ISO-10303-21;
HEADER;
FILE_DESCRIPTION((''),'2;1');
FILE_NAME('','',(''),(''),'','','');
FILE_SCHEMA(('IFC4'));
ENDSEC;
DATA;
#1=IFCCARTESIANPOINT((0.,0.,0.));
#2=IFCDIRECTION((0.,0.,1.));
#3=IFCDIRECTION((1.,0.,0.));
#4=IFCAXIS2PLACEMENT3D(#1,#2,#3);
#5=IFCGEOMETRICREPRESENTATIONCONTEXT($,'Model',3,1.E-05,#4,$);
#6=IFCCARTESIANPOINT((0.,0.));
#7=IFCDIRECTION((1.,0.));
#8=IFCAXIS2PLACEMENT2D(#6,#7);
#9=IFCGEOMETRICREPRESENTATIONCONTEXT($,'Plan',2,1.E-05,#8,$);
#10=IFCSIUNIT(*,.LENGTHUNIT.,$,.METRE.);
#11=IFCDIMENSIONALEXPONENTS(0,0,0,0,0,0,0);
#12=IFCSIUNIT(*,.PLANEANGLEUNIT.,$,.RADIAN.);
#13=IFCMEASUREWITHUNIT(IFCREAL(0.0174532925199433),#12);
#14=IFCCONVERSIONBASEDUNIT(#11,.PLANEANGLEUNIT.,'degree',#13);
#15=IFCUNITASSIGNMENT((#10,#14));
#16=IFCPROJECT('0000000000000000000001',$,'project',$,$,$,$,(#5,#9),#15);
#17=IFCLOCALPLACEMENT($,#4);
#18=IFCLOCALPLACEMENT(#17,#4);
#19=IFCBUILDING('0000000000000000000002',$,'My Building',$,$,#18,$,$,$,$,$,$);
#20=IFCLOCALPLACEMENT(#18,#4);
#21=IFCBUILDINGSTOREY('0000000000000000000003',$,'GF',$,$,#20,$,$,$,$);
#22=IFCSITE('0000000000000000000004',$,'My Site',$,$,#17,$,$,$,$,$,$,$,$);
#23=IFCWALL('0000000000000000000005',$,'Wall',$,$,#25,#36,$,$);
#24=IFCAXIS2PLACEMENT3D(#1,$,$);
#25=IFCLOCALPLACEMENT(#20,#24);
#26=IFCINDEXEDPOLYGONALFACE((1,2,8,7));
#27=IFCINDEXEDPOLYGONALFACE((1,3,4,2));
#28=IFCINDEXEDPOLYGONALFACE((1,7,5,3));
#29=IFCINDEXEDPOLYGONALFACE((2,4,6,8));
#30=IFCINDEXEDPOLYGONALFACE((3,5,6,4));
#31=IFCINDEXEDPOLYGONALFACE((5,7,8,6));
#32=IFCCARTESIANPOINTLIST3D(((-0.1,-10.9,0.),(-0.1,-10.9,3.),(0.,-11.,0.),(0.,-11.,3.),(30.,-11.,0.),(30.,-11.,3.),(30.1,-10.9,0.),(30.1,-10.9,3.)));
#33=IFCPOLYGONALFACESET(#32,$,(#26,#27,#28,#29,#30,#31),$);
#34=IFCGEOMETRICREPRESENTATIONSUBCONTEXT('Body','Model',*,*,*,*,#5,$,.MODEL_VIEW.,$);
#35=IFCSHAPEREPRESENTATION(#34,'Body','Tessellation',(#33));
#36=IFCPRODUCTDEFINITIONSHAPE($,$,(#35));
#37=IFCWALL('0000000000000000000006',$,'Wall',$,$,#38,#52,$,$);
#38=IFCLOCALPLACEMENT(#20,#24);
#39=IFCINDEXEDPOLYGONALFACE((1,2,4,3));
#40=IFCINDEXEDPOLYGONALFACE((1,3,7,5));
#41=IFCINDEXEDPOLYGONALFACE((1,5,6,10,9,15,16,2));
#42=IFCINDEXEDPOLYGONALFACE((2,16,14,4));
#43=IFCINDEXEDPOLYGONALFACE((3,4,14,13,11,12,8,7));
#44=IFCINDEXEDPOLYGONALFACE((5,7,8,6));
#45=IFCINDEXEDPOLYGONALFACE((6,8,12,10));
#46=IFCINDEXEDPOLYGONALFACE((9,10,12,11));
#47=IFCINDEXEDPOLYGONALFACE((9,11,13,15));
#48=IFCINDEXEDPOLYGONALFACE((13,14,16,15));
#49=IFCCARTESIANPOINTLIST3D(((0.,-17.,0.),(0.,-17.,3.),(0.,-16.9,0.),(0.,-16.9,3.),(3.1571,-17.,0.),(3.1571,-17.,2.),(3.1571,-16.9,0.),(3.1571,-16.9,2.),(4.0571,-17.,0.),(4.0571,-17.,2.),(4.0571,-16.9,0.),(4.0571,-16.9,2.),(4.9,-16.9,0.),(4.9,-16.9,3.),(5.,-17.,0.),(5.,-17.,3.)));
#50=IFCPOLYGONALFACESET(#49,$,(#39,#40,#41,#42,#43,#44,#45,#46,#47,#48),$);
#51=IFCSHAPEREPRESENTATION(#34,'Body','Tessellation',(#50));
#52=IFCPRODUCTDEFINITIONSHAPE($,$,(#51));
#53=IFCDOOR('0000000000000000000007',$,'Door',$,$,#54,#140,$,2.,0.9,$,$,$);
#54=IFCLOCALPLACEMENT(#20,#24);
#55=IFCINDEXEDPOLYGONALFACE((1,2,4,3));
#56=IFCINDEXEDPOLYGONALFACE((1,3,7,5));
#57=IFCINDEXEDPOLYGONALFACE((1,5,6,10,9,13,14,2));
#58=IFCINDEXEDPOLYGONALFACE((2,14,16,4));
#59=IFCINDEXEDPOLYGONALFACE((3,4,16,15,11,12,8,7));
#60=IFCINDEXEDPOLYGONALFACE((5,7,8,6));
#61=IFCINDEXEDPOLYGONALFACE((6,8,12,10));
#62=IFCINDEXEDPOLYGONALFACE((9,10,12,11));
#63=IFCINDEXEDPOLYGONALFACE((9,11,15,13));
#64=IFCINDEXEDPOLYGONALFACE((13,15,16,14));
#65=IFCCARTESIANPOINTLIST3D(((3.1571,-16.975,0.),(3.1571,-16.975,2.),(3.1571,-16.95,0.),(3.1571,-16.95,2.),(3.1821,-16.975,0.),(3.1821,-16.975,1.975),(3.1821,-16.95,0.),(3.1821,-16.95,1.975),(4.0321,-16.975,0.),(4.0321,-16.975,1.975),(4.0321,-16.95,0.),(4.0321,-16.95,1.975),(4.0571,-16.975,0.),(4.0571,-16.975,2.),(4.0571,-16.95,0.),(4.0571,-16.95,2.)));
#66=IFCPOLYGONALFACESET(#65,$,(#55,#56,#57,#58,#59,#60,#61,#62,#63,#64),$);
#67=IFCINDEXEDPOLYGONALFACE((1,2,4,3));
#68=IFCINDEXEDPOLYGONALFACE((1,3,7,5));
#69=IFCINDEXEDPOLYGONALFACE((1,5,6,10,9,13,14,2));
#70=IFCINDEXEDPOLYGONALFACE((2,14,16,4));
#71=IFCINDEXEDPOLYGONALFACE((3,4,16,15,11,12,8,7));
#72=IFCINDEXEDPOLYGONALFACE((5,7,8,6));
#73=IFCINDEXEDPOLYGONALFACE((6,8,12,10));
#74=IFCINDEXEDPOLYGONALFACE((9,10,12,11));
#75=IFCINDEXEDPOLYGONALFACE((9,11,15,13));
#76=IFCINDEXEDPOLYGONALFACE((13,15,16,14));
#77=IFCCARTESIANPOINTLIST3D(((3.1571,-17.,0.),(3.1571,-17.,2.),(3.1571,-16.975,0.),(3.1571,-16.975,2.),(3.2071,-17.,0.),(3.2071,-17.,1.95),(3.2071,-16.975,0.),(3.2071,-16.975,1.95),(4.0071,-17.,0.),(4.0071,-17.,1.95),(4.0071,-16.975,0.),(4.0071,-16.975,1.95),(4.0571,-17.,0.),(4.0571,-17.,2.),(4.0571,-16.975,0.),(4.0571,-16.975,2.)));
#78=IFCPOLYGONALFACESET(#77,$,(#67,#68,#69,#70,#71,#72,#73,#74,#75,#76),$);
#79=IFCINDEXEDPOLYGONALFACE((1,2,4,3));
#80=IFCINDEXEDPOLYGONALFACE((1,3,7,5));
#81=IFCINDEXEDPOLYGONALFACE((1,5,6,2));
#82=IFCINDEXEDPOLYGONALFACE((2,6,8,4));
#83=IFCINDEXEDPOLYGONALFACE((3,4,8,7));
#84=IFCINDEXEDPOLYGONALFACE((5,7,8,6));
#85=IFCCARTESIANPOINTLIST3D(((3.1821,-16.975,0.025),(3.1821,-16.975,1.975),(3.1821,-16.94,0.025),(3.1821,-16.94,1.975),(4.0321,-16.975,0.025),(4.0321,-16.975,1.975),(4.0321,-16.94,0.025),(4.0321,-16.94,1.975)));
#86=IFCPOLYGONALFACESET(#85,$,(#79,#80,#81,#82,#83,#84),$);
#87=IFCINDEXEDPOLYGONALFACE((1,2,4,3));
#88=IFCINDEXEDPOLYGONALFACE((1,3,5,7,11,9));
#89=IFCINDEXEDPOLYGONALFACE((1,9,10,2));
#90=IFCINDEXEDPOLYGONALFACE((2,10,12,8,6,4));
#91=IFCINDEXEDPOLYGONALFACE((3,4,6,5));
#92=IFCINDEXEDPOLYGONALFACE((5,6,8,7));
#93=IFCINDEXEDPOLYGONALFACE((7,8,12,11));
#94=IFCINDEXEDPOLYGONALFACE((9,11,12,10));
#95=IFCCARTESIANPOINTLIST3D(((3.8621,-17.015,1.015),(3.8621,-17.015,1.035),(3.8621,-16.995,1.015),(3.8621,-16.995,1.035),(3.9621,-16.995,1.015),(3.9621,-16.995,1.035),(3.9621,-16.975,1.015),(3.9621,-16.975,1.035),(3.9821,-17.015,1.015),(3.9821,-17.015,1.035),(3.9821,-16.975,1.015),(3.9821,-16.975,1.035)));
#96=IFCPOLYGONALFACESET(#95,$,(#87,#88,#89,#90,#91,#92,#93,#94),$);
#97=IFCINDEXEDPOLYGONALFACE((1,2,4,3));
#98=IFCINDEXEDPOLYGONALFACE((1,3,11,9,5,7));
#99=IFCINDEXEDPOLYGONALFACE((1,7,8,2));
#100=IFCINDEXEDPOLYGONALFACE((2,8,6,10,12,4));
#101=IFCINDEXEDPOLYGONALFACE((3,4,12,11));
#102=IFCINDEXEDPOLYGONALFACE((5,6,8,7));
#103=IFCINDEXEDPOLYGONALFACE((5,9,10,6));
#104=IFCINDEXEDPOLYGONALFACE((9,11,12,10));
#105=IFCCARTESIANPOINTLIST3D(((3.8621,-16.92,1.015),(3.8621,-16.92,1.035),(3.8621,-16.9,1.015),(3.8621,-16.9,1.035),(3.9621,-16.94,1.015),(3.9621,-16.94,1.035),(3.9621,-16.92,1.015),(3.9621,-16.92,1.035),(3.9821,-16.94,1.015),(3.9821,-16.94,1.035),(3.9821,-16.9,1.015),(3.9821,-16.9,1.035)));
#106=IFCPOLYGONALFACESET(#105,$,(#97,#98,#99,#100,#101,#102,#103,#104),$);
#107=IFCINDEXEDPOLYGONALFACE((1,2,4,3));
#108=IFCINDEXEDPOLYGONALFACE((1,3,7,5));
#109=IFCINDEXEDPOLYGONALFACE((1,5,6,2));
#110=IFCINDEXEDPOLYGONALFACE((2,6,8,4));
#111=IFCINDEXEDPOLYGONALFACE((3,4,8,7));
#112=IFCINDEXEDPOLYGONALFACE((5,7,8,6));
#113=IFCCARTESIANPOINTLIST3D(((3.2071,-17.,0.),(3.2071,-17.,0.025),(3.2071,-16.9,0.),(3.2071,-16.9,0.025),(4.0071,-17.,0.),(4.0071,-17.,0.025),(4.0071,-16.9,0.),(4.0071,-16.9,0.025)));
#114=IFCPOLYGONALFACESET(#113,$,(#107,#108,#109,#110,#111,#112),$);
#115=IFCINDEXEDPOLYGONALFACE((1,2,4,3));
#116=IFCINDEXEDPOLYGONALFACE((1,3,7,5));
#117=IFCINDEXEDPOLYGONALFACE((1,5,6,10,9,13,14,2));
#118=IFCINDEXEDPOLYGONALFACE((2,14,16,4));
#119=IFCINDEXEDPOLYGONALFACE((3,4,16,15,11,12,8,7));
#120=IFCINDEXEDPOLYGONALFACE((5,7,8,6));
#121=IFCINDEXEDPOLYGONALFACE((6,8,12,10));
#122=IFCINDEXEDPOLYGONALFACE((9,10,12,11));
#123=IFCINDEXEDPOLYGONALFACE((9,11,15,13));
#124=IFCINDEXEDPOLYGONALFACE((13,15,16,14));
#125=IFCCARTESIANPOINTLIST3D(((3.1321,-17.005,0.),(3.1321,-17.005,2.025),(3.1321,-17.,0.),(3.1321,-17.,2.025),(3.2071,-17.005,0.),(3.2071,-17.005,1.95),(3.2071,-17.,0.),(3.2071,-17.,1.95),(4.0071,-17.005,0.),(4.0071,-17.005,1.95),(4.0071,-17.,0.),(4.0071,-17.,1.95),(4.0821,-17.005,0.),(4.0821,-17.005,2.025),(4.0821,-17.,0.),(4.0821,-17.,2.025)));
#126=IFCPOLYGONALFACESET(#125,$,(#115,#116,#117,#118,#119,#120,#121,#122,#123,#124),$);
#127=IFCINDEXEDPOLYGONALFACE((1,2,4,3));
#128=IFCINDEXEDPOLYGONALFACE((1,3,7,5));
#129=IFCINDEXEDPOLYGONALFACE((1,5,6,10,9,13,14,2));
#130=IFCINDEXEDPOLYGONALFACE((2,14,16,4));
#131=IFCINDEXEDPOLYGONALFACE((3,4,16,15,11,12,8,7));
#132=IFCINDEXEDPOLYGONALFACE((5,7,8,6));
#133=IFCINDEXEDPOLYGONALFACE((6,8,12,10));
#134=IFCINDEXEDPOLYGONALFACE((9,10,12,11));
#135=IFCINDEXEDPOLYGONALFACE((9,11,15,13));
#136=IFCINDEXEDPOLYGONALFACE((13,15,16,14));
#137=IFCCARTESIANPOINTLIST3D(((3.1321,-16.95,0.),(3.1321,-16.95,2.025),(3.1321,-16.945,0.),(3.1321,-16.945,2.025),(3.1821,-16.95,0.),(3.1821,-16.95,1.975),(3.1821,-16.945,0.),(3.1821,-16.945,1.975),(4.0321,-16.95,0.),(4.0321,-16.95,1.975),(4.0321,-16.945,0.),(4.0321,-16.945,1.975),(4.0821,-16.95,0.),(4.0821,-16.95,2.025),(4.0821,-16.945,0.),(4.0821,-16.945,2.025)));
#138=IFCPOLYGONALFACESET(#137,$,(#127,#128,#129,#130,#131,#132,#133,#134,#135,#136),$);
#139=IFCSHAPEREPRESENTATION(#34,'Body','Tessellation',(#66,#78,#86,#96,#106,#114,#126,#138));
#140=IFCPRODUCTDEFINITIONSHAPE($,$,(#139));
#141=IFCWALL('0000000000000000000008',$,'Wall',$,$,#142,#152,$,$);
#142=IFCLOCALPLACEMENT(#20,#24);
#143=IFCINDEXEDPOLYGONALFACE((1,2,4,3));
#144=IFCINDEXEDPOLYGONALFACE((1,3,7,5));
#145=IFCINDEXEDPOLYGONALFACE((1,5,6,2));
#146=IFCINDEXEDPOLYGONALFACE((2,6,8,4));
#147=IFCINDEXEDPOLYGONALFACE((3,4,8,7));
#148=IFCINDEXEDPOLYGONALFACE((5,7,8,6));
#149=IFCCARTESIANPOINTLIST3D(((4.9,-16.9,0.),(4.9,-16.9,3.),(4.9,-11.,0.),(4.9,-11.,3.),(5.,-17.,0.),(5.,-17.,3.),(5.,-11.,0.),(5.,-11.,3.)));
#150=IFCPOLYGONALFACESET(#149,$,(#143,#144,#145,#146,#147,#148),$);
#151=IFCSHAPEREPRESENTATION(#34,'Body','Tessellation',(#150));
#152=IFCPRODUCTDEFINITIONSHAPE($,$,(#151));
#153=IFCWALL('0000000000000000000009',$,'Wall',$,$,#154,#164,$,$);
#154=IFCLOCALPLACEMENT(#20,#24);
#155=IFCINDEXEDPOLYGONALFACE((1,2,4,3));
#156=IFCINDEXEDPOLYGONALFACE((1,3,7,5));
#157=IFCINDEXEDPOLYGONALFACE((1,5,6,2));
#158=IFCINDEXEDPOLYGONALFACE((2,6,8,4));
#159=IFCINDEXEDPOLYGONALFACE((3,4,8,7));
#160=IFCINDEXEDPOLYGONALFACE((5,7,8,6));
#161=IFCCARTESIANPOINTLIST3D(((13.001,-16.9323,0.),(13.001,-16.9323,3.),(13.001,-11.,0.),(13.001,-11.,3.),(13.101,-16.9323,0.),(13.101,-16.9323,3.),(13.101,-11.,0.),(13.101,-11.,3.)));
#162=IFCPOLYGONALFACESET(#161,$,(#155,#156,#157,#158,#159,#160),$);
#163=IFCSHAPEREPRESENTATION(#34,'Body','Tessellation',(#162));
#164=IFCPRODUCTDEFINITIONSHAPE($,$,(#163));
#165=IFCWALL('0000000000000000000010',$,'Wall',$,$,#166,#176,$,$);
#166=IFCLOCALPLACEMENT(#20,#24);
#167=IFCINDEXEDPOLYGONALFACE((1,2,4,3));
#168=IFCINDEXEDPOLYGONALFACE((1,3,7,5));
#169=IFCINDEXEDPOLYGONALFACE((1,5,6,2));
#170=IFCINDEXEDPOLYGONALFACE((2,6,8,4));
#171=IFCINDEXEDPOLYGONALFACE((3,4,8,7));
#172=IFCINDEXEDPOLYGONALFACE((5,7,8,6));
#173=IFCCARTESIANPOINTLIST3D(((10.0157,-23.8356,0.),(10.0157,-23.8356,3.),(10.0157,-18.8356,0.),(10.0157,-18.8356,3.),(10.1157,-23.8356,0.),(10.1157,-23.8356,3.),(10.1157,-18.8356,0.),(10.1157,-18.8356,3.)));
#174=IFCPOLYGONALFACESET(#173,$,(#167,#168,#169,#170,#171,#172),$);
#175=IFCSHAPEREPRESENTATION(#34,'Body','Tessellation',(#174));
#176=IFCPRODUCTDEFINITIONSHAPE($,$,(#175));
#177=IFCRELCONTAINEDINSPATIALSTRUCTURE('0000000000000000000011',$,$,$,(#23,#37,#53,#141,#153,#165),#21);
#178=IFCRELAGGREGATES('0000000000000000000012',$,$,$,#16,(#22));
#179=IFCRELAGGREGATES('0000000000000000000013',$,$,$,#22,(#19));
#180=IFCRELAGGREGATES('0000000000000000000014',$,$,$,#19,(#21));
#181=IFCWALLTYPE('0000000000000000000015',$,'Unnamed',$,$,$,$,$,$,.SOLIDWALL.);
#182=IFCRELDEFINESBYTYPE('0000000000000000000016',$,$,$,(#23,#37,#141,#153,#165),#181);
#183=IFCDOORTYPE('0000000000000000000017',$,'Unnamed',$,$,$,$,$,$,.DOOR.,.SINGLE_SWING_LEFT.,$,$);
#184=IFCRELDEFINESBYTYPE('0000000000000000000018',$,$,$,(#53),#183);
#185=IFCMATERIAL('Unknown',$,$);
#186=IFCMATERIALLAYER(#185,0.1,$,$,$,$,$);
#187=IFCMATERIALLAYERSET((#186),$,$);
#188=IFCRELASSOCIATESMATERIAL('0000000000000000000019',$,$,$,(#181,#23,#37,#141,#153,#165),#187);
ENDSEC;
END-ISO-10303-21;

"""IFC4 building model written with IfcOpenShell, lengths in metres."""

from ifc_helpers import new_model, entity, si_unit, converted_unit, frame, origin_with_axes, origin_2d_with_axis, place, context, subcontext, project, spatial, line, indexed_curve, outline, extrude, shape, source, transform, mapped, material, layer, layer_set, layer_usage, type_object, type_shapes, element, fill, save


model = new_model("IFC4")

# Units and contexts
model_context = context("Model", 3, precision=1e-05, world=origin_with_axes())
plan_context = context("Plan", 2, precision=1e-05, world=origin_2d_with_axis())
body_context_1 = subcontext(model_context, "Body", "Model", "MODEL_VIEW")
body_context_2 = subcontext(plan_context, "Body", "Plan", "PLAN_VIEW")
ifc_project = project(units=[si_unit("LENGTHUNIT", "METRE"), converted_unit("PLANEANGLEUNIT", "degree", entity("IfcReal", 0.0174532925199433), si_unit("PLANEANGLEUNIT", "RADIAN"), dimensions=[0, 0, 0, 0, 0, 0, 0])], contexts=[model_context, plan_context])

# Site, building, storey
site_placement = place(None, origin_with_axes())
site = spatial("IfcSite", under=ifc_project, at=site_placement, Name="My Site")
building_placement = place(site_placement, origin_with_axes())
building = spatial("IfcBuilding", under=site, at=building_placement, Name="My Building")
storey_placement = place(building_placement, origin_with_axes())
storey = spatial("IfcBuildingStorey", under=building, at=storey_placement, Name="GF")

# Wall
ifc_material = material(Name="Unknown")
ifc_layer = layer(ifc_material, 0.1)
ifc_layer_set = layer_set([ifc_layer])
ifc_layer_usage_1 = layer_usage(ifc_layer_set, "AXIS2", "POSITIVE", 0.0)
wall_type = type_object("IfcWallType", Name="Unnamed", PredefinedType="SOLIDWALL", material=ifc_layer_set)
wall_1_placement = place(storey_placement, frame((0.0, -11.0, 0.0), z_axis=(0.0, 0.0, 1.0), x_axis=(1.0, 0.0, 0.0)))
element("IfcWall", 1, at=wall_1_placement, inside=storey, type_object=wall_type, material=ifc_layer_usage_1, Name="Wall", context=body_context_1, shape_type="SweptSolid", body=[
    extrude(outline(indexed_curve([(0.0, 0.0), (-0.1, 0.1), (30.1, 0.1), (30.0, 0.0)], segments=[line(1, 2, 3, 4, 1)])), origin_with_axes(), (0.0, 0.0, 1.0), 3.0),
])

# Wall, opening, door
ifc_layer_usage_2 = layer_usage(ifc_layer_set, "AXIS2", "POSITIVE", 0.0)
wall_2_placement = place(storey_placement, frame((0.0, -17.0, 0.0), z_axis=(0.0, 0.0, 1.0), x_axis=(1.0, 0.0, 0.0)))
wall_2 = element("IfcWall", 2, at=wall_2_placement, inside=storey, type_object=wall_type, material=ifc_layer_usage_2, Name="Wall", context=body_context_1, shape_type="SweptSolid", body=[
    extrude(outline(indexed_curve([(0.0, 0.0), (0.0, 0.1), (4.9, 0.1), (5.0, 0.0)], segments=[line(1, 2, 3, 4, 1)])), origin_with_axes(), (0.0, 0.0, 1.0), 3.0),
])
shared_shape_1 = source(origin_with_axes(), body_context_1, "Body", "SweptSolid", [
    extrude(outline(indexed_curve([(0.0, 0.0), (0.9, 0.0), (0.9, 2.0), (0.0, 2.0)], segments=[line(1, 2, 3, 4, 1)])), frame((0.0, -0.6, 0.0), z_axis=(0.0, -1.0, 0.0), x_axis=(1.0, 0.0, 0.0)), (0.0, 0.0, -1.0), 1.2),
])
opening_1_placement = place(wall_2_placement, frame((3.1571, 0.0, 0.0), z_axis=(0.0, 0.0, 1.0), x_axis=(1.0, 0.0, 0.0)))
opening_1 = element("IfcOpeningElement", 3, at=opening_1_placement, cuts=wall_2, PredefinedType="OPENING", context=body_context_1, shape_type="MappedRepresentation", body=[
    mapped(shared_shape_1, transform((0.0, 0.0, 0.0), x_axis=(1.0, 0.0, 0.0), y_axis=(0.0, 1.0, 0.0), z_axis=(0.0, 0.0, 1.0), scale=1.0)),
])
door_type = type_object("IfcDoorType", Name="Unnamed", OperationType="SINGLE_SWING_LEFT", PredefinedType="DOOR")
shared_shape_2 = source(origin_with_axes(), body_context_1, "Body", "SweptSolid", [
    extrude(outline(indexed_curve([(0.0, 0.0), (0.0, 2.0), (0.9, 2.0), (0.9, 0.0), (0.875, 0.0), (0.875, 1.975), (0.025, 1.975), (0.025, 0.0)], segments=[line(1, 2, 3, 4, 5, 6, 7, 8, 1)])), frame((0.0, 0.025, 0.0), z_axis=(0.0, -1.0, 0.0), x_axis=(1.0, 0.0, 0.0)), (0.0, 0.0, -1.0), 0.025),
    extrude(outline(indexed_curve([(0.0, 0.0), (0.0, 2.0), (0.9, 2.0), (0.9, 0.0), (0.85, 0.0), (0.85, 1.95), (0.05, 1.95), (0.05, 0.0)], segments=[line(1, 2, 3, 4, 5, 6, 7, 8, 1)])), frame((0.0, 0.0, 0.0), z_axis=(0.0, -1.0, 0.0), x_axis=(1.0, 0.0, 0.0)), (0.0, 0.0, -1.0), 0.025),
    extrude(outline(indexed_curve([(0.0, 0.0), (0.85, 0.0), (0.85, 0.035), (0.0, 0.035)], segments=[line(1, 2, 3, 4, 1)])), frame((0.025, 0.025, 0.025), z_axis=(0.0, 0.0, 1.0), x_axis=(1.0, 0.0, 0.0)), (0.0, 0.0, 1.0), 1.95),
    extrude(outline(indexed_curve([(0.0, 0.0), (0.0, -0.04), (-0.12, -0.04), (-0.12, -0.02), (-0.02, -0.02), (-0.02, 0.0)], segments=[line(1, 2, 3, 4, 5, 6, 1)])), frame((0.825, 0.025, 1.015), z_axis=(0.0, 0.0, 1.0), x_axis=(1.0, 0.0, 0.0)), (0.0, 0.0, 1.0), 0.02),
    extrude(outline(indexed_curve([(0.0, 0.0), (0.0, 0.04), (-0.12, 0.04), (-0.12, 0.02), (-0.02, 0.02), (-0.02, 0.0)], segments=[line(1, 2, 3, 4, 5, 6, 1)])), frame((0.825, 0.06, 1.015), z_axis=(0.0, 0.0, 1.0), x_axis=(1.0, 0.0, 0.0)), (0.0, 0.0, 1.0), 0.02),
    extrude(outline(indexed_curve([(0.0, 0.0), (0.8, 0.0), (0.8, 0.1), (0.0, 0.1)], segments=[line(1, 2, 3, 4, 1)])), frame((0.05, 0.0, 0.0), z_axis=(0.0, 0.0, 1.0), x_axis=(1.0, 0.0, 0.0)), (0.0, 0.0, 1.0), 0.025),
    extrude(outline(indexed_curve([(0.0, 0.0), (0.0, 2.025), (0.95, 2.025), (0.95, 0.0), (0.875, 0.0), (0.875, 1.95), (0.075, 1.95), (0.075, 0.0)], segments=[line(1, 2, 3, 4, 5, 6, 7, 8, 1)])), frame((-0.025, -0.005, 0.0), z_axis=(0.0, -1.0, 0.0), x_axis=(1.0, 0.0, 0.0)), (0.0, 0.0, -1.0), 0.005),
    extrude(outline(indexed_curve([(0.0, 0.0), (0.0, 2.025), (0.95, 2.025), (0.95, 0.0), (0.9, 0.0), (0.9, 1.975), (0.05, 1.975), (0.05, 0.0)], segments=[line(1, 2, 3, 4, 5, 6, 7, 8, 1)])), frame((-0.025, 0.05, 0.0), z_axis=(0.0, -1.0, 0.0), x_axis=(1.0, 0.0, 0.0)), (0.0, 0.0, -1.0), 0.005),
])
shared_shape_3 = source(origin_with_axes(), body_context_2, "Body", "Curve2D", [
    entity("IfcIndexedPolyCurve", entity("IfcCartesianPointList2D", [[0.0, 0.0], [0.0, 0.05], [0.025, 0.05], [0.025, 0.025], [0.05, 0.025], [0.05, 0.0]]), [entity("IfcLineIndex", [1, 2, 3, 4, 5, 6, 1])]),
    entity("IfcIndexedPolyCurve", entity("IfcCartesianPointList2D", [[0.9, 0.0], [0.9, 0.05], [0.875, 0.05], [0.875, 0.025], [0.85, 0.025], [0.85, 0.0]]), [entity("IfcLineIndex", [1, 2, 3, 4, 5, 6, 1])]),
    entity("IfcTrimmedCurve", entity("IfcEllipse", entity("IfcAxis2Placement2D", entity("IfcCartesianPoint", [0.06, 0.05]), entity("IfcDirection", [1.0, 0.0])), 0.815, 0.85), [entity("IfcCartesianPoint", [0.875, 0.05])], [entity("IfcCartesianPoint", [0.06, 0.9])], True, "CARTESIAN"),
    entity("IfcIndexedPolyCurve", entity("IfcCartesianPointList2D", [[0.025, 0.05], [0.06, 0.05], [0.06, 0.9], [0.025, 0.9]]), [entity("IfcLineIndex", [1, 2, 3, 4, 1])]),
])
type_shapes(door_type, [shared_shape_2, shared_shape_3])
door_1_placement = place(opening_1_placement, origin_with_axes())
door_1 = element("IfcDoor", 4, at=door_1_placement, inside=storey, type_object=door_type, Name="Door", OverallHeight=2.0, OverallWidth=0.9, shapes=[
    shape(body_context_1, "Body", "MappedRepresentation", [mapped(shared_shape_2, transform((0.0, 0.0, 0.0), x_axis=(1.0, 0.0, 0.0), y_axis=(0.0, 1.0, 0.0), z_axis=(0.0, 0.0, 1.0), scale=1.0))]),
    shape(body_context_2, "Body", "MappedRepresentation", [mapped(shared_shape_3, transform((0.0, 0.0, 0.0), x_axis=(1.0, 0.0, 0.0), y_axis=(0.0, 1.0, 0.0), z_axis=(0.0, 0.0, 1.0), scale=1.0))]),
])
fill(opening_1, door_1)

# Wall
ifc_layer_usage_3 = layer_usage(ifc_layer_set, "AXIS2", "POSITIVE", 0.0)
wall_3_placement = place(storey_placement, frame((5.0, -17.0, 0.0), z_axis=(0.0, 0.0, 1.0), x_axis=(0.0, 1.0, 0.0)))
element("IfcWall", 5, at=wall_3_placement, inside=storey, type_object=wall_type, material=ifc_layer_usage_3, Name="Wall", context=body_context_1, shape_type="SweptSolid", body=[
    extrude(outline(indexed_curve([(0.0, 0.0), (0.1, 0.1), (6.0, 0.1), (6.0, 0.0)], segments=[line(1, 2, 3, 4, 1)])), origin_with_axes(), (0.0, 0.0, 1.0), 3.0),
])

# Walls
ifc_layer_usage_4 = layer_usage(ifc_layer_set, "AXIS2", "POSITIVE", 0.0)
wall_4_placement = place(storey_placement, frame((13.101, -16.9323, 0.0), z_axis=(0.0, 0.0, 1.0), x_axis=(0.0, 1.0, 0.0)))
element("IfcWall", 6, at=wall_4_placement, inside=storey, type_object=wall_type, material=ifc_layer_usage_4, Name="Wall", context=body_context_1, shape_type="SweptSolid", body=[
    extrude(outline(indexed_curve([(0.0, 0.0), (0.0, 0.1), (5.9323, 0.1), (5.9323, 0.0)], segments=[line(1, 2, 3, 4, 1)])), origin_with_axes(), (0.0, 0.0, 1.0), 3.0),
])
ifc_layer_usage_5 = layer_usage(ifc_layer_set, "AXIS2", "POSITIVE", 0.0)
wall_5_placement = place(storey_placement, frame((10.0157, -18.8356, 0.0), z_axis=(0.0, 0.0, 1.0), x_axis=(0.0, -1.0, 0.0)))
element("IfcWall", 7, at=wall_5_placement, inside=storey, type_object=wall_type, material=ifc_layer_usage_5, Name="Wall", context=body_context_1, shape_type="SweptSolid", body=[
    extrude(outline(indexed_curve([(0.0, 0.0), (0.0, 0.1), (5.0, 0.1), (5.0, 0.0)], segments=[line(1, 2, 3, 4, 1)])), origin_with_axes(), (0.0, 0.0, 1.0), 3.0),
])

save(model, "model.ifc")
